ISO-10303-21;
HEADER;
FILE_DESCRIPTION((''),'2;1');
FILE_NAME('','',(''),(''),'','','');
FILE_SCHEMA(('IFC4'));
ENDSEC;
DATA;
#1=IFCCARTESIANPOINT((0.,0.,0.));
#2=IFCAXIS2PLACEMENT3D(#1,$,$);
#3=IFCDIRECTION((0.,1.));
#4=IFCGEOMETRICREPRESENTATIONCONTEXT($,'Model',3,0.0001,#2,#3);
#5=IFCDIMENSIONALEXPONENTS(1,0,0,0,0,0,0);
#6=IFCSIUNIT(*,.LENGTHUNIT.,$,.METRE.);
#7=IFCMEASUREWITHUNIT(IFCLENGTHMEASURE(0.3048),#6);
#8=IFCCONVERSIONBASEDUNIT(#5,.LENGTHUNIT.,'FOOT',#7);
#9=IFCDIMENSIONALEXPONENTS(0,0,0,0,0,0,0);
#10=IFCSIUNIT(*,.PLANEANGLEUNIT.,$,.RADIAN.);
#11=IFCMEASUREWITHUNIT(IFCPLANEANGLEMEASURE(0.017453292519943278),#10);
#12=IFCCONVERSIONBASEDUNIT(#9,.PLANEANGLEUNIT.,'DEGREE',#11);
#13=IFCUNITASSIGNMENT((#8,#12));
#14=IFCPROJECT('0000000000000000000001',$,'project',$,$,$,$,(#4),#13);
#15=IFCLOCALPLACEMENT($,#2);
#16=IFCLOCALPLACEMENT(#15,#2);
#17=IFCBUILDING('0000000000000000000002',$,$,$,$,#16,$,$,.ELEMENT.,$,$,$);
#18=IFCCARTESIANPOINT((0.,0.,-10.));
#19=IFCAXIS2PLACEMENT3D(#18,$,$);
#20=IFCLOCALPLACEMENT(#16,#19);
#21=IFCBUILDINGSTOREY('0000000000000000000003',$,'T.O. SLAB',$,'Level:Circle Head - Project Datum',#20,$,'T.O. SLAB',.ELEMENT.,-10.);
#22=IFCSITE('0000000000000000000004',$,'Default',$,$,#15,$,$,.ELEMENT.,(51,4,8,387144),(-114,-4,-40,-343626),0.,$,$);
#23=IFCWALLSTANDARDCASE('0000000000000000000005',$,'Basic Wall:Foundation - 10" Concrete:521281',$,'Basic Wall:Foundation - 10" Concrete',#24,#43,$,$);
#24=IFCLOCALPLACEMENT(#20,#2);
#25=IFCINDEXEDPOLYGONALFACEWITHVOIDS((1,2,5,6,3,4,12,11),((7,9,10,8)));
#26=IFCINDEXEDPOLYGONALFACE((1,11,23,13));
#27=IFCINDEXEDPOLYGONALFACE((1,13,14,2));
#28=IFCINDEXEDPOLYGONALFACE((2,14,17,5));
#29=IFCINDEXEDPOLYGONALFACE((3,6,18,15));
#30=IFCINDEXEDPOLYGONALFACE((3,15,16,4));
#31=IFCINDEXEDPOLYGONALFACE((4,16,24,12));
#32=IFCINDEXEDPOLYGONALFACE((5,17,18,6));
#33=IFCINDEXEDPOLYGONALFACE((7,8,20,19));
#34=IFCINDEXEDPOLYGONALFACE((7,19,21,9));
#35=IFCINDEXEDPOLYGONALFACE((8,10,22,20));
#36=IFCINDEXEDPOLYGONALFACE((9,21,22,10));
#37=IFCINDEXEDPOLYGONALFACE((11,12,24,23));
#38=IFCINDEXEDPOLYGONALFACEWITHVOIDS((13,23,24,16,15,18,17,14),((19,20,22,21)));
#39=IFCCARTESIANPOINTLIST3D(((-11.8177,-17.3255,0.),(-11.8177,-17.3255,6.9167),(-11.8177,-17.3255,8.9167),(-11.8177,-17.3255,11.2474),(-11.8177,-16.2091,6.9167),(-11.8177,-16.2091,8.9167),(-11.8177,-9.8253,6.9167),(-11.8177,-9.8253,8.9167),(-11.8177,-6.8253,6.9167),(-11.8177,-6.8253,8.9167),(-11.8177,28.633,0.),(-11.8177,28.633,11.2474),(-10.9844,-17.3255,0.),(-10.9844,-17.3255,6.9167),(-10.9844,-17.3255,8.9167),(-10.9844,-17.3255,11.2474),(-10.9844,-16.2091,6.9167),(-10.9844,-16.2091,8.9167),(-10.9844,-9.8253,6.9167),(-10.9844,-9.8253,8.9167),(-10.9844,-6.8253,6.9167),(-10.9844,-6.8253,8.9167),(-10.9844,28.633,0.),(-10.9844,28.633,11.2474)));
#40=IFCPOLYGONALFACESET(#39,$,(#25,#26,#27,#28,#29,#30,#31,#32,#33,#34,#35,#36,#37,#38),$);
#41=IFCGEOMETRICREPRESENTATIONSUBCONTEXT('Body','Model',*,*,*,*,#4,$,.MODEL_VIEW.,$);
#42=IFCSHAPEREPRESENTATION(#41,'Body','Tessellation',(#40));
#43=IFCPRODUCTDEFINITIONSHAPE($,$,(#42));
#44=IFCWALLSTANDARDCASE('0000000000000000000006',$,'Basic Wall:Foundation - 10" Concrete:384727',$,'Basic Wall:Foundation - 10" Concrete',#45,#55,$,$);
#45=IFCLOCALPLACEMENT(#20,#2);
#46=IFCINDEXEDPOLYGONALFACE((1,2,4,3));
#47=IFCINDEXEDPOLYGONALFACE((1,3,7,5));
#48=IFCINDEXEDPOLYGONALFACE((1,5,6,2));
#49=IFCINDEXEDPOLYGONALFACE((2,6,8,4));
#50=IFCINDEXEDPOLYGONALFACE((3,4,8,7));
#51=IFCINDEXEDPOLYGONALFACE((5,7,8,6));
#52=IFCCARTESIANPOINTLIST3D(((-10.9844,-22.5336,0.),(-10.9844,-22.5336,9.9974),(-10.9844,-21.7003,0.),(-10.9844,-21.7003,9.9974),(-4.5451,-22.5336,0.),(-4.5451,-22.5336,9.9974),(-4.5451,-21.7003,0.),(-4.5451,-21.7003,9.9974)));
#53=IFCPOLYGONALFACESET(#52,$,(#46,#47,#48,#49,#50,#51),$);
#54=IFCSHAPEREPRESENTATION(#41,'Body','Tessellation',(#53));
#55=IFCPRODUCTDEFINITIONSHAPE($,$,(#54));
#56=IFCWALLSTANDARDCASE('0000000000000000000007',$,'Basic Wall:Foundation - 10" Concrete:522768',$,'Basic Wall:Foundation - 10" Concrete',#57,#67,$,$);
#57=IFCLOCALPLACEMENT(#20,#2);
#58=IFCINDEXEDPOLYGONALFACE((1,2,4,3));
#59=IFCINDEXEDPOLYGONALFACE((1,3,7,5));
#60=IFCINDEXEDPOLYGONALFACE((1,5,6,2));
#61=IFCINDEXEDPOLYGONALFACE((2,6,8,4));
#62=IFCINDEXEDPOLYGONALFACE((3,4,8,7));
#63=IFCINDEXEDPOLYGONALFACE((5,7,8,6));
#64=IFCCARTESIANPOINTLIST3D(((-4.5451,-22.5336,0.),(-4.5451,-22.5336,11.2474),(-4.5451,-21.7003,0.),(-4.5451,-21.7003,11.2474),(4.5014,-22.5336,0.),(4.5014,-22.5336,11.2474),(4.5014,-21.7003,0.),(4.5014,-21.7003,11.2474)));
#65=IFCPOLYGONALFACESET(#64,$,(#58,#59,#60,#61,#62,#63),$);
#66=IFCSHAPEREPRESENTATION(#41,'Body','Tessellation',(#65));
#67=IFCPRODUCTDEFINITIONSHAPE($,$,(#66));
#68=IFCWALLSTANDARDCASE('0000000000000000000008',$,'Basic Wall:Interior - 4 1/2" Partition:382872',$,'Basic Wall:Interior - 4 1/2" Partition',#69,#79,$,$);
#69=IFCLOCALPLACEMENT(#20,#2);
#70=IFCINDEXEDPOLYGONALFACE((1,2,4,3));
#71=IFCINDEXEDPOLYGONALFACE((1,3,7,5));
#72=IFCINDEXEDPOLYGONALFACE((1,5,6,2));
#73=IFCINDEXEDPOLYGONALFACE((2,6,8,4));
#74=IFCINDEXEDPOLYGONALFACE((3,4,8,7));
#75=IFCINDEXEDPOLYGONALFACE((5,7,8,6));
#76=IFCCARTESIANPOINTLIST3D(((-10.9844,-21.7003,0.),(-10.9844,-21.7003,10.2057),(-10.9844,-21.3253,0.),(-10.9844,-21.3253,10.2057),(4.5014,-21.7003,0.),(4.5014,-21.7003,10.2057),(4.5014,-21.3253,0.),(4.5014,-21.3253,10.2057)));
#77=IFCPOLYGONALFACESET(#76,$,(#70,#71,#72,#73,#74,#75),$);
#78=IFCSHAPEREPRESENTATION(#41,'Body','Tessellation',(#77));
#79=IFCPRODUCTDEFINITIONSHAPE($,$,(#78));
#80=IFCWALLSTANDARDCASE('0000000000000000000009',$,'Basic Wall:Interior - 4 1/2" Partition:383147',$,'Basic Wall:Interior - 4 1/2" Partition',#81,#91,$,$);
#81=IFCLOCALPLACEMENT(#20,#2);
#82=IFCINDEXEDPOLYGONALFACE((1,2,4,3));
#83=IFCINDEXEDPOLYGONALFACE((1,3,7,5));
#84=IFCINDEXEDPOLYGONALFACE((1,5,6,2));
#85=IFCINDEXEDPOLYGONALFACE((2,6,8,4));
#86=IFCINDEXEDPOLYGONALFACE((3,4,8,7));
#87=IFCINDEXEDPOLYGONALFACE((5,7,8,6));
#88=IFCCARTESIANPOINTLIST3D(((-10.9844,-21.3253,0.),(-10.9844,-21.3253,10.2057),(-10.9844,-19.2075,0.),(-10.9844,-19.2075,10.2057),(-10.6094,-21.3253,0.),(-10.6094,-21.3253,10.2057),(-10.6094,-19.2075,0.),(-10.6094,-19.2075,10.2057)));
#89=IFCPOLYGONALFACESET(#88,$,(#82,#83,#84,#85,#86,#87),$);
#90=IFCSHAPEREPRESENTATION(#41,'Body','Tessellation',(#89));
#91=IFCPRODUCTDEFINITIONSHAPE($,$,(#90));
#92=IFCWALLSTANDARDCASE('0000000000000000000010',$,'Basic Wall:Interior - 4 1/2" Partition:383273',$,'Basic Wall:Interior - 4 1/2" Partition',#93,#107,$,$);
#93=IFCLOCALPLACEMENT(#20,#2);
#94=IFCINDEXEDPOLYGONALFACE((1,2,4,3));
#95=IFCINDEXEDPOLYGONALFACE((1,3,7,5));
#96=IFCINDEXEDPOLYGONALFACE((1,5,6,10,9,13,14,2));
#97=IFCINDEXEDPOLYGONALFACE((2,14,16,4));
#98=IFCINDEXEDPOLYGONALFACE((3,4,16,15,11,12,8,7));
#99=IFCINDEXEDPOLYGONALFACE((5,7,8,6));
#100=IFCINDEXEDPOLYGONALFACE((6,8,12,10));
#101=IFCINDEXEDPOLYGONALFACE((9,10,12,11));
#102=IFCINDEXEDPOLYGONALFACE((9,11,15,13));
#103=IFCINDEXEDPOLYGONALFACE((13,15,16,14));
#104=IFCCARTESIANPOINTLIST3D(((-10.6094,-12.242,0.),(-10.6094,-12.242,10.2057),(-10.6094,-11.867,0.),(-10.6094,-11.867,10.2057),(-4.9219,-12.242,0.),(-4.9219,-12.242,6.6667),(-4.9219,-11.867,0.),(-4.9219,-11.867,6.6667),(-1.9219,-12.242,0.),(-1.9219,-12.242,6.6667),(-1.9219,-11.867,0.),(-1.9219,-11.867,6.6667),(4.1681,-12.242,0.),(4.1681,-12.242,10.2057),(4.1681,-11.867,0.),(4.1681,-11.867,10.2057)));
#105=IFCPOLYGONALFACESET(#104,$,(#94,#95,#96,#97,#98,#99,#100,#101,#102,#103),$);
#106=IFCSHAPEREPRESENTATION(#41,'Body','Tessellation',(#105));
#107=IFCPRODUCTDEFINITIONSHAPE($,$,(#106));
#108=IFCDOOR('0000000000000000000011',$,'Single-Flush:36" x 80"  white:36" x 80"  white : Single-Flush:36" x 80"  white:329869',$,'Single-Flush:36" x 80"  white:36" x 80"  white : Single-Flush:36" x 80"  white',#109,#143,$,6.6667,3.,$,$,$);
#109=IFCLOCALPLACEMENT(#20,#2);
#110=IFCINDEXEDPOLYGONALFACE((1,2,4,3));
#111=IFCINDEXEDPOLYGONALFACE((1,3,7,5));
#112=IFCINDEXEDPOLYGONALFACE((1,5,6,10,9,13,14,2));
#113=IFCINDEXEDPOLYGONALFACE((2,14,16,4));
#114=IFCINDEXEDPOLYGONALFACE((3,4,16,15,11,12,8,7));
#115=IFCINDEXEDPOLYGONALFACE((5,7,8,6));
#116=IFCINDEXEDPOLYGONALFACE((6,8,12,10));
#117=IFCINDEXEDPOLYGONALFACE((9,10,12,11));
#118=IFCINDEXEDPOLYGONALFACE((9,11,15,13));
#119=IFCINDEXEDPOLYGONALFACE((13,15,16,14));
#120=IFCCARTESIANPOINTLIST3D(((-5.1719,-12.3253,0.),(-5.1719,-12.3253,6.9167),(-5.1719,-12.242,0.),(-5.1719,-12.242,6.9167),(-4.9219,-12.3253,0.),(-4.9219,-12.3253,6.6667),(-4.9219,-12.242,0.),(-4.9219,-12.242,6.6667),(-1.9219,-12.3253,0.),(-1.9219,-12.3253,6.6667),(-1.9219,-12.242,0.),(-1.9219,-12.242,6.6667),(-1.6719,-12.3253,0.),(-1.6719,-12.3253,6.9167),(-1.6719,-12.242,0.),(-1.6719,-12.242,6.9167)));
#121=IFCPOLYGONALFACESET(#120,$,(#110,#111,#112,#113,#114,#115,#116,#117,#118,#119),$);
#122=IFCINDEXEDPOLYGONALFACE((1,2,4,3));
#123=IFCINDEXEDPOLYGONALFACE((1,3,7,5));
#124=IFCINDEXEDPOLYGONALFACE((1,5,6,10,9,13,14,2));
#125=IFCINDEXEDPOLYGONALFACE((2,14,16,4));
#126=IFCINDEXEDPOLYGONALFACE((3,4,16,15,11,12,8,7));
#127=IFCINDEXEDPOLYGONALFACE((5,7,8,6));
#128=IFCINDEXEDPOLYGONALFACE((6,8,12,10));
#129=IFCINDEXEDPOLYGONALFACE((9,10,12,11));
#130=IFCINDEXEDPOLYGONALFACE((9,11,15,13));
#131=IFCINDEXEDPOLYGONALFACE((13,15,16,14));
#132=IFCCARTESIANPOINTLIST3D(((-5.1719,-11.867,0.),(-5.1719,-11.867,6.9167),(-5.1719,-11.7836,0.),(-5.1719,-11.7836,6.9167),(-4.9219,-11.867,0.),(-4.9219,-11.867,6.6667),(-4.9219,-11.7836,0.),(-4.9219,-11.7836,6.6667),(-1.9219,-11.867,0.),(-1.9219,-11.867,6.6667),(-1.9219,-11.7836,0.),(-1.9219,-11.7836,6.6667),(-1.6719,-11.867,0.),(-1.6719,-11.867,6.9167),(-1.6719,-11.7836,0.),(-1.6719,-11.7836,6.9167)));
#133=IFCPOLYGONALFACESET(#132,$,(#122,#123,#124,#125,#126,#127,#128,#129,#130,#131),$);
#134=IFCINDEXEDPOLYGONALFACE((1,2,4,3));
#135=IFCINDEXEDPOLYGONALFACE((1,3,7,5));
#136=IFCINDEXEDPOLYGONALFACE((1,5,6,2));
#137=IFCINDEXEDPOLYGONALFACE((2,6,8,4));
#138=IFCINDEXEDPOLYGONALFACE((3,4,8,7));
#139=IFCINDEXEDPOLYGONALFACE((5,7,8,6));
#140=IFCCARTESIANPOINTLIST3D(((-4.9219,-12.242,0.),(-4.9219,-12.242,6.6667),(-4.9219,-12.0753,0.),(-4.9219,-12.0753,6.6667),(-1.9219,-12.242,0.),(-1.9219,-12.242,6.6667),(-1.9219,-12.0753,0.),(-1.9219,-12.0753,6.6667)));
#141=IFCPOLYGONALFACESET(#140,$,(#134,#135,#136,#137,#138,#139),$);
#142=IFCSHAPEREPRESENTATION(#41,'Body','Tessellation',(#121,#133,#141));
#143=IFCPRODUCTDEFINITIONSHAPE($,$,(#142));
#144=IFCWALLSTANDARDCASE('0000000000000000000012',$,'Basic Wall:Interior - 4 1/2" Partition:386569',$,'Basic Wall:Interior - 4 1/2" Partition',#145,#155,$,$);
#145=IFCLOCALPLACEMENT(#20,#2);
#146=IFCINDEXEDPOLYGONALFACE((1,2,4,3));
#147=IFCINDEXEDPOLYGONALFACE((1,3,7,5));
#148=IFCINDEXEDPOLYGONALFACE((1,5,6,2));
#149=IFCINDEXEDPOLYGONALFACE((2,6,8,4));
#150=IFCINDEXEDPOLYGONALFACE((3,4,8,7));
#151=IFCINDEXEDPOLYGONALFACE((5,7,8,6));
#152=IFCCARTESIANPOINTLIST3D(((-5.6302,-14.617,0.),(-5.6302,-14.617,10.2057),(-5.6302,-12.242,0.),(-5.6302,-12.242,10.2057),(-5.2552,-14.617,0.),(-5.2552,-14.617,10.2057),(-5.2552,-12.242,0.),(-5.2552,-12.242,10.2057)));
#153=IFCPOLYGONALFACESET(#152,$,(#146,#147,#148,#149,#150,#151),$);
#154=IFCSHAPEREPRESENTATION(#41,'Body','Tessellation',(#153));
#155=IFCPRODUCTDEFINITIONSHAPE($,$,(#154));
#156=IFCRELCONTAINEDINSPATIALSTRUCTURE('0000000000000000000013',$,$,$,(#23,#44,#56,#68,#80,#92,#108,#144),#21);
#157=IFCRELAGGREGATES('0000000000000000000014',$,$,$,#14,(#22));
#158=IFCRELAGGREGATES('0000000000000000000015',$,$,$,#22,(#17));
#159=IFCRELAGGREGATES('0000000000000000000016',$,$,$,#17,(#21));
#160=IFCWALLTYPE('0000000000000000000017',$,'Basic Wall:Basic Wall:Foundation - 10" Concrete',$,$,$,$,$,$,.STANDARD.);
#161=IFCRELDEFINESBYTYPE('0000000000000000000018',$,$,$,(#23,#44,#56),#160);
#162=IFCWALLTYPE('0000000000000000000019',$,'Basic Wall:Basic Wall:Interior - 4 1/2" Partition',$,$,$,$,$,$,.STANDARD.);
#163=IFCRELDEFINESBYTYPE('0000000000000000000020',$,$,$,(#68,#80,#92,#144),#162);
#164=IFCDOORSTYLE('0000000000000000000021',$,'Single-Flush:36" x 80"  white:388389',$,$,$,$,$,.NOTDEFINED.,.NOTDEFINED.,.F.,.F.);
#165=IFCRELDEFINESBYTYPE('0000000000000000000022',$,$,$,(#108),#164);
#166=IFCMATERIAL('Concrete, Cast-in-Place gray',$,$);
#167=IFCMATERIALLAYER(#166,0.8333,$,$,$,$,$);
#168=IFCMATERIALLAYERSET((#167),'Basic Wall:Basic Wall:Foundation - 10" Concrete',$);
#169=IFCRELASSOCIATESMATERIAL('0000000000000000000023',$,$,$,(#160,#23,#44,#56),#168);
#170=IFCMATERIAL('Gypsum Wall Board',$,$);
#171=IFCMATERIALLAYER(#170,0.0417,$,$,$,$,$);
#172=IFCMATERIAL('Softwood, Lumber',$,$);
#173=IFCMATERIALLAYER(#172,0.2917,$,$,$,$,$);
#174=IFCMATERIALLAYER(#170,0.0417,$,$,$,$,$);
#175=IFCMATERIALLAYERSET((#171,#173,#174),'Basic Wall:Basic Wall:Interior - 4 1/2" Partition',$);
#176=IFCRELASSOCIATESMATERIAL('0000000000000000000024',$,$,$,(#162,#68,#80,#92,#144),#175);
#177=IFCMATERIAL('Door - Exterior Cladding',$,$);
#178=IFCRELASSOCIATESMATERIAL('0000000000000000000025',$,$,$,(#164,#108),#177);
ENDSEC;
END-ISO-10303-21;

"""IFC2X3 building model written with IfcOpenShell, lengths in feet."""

from ifc_helpers import new_model, entity, si_unit, converted_unit, direction, frame, frame_2d, origin, origin_2d_with_axis, place, context, subcontext, project, spatial, polyline, rectangle, outline, extrude, source, transform, mapped, material, layer, layer_set, layer_usage, type_object, type_shapes, element, fill, save


model = new_model("IFC2X3")

# Units and contexts
model_context = context("Model", 3, precision=0.0001, world=origin(), true_north=direction((0.0, 1.0)))
body_context = subcontext(model_context, "Body", "Model", "MODEL_VIEW")
ifc_project = project(units=[converted_unit("LENGTHUNIT", "FOOT", entity("IfcLengthMeasure", 0.3048), si_unit("LENGTHUNIT", "METRE"), dimensions=[1, 0, 0, 0, 0, 0, 0]), converted_unit("PLANEANGLEUNIT", "DEGREE", entity("IfcPlaneAngleMeasure", 0.017453292519943278), si_unit("PLANEANGLEUNIT", "RADIAN"), dimensions=[0, 0, 0, 0, 0, 0, 0])], contexts=[model_context])

# Site, building, storey
site_placement = place(None, origin())
site = spatial("IfcSite", under=ifc_project, at=site_placement, Name="Default", CompositionType="ELEMENT", RefLatitude=(51, 4, 8, 387144), RefLongitude=(-114, -4, -40, -343626), RefElevation=0.0)
building_placement = place(site_placement, origin())
building = spatial("IfcBuilding", under=site, at=building_placement, CompositionType="ELEMENT")
storey_placement = place(building_placement, frame((0.0, 0.0, -10.0)))
storey = spatial("IfcBuildingStorey", under=building, at=storey_placement, Name="T.O. SLAB", ObjectType="Level:Circle Head - Project Datum", LongName="T.O. SLAB", CompositionType="ELEMENT", Elevation=-10.0)

# Wall, openings
ifc_material_1 = material(Name="Concrete, Cast-in-Place gray")
ifc_layer_1 = layer(ifc_material_1, 0.8333)
ifc_layer_set_1 = layer_set([ifc_layer_1], Name="Basic Wall:Basic Wall:Foundation - 10\" Concrete")
ifc_layer_usage_1 = layer_usage(ifc_layer_set_1, "AXIS2", "NEGATIVE", 0.4167)
wall_type_1 = type_object("IfcWallType", Name="Basic Wall:Basic Wall:Foundation - 10\" Concrete", PredefinedType="STANDARD", material=ifc_layer_set_1)
wall_1_placement = place(storey_placement, frame((-11.401, -17.3255, 0.0), z_axis=(0.0, 0.0, 1.0), x_axis=(0.0, 1.0, 0.0)))
wall_1 = element("IfcWallStandardCase", 1, at=wall_1_placement, inside=storey, type_object=wall_type_1, material=ifc_layer_usage_1, Name="Basic Wall:Foundation - 10\" Concrete:521281", ObjectType="Basic Wall:Foundation - 10\" Concrete", context=body_context, shape_type="SweptSolid", body=[
    extrude(rectangle(XDim=45.9585, YDim=0.8333, at=frame_2d((22.9792, 0.0), x_axis=(-1.0, 0.0))), origin(), (0.0, 0.0, 1.0), 11.2474),
])
opening_1_placement = place(wall_1_placement, origin())
element("IfcOpeningElement", 2, at=opening_1_placement, cuts=wall_1, ObjectType="Opening", context=body_context, shape_type="SweptSolid", body=[
    extrude(rectangle(XDim=2.0, YDim=3.0, at=origin_2d_with_axis()), frame((-0.3836, -0.4167, 7.9167), z_axis=(0.0, 1.0, 0.0), x_axis=(0.0, 0.0, -1.0)), (0.0, 0.0, 1.0), 0.8333),
])
opening_2_placement = place(wall_1_placement, frame((17.3255, -11.401, 0.0), z_axis=(0.0, 0.0, 1.0), x_axis=(0.0, -1.0, 0.0)))
element("IfcOpeningElement", 3, at=opening_2_placement, cuts=wall_1, ObjectType="Opening", context=body_context, shape_type="SweptSolid", body=[
    extrude(rectangle(XDim=2.0, YDim=3.0, at=origin_2d_with_axis()), frame((-10.976, -8.3253, 7.9167), z_axis=(-1.0, 0.0, 0.0), x_axis=(0.0, 0.0, 1.0)), (0.0, 0.0, 1.0), 0.85),
])

# Walls
ifc_layer_usage_2 = layer_usage(ifc_layer_set_1, "AXIS2", "NEGATIVE", 0.4167)
wall_2_placement = place(storey_placement, frame((-10.9844, -22.117, 0.0)))
element("IfcWallStandardCase", 4, at=wall_2_placement, inside=storey, type_object=wall_type_1, material=ifc_layer_usage_2, Name="Basic Wall:Foundation - 10\" Concrete:384727", ObjectType="Basic Wall:Foundation - 10\" Concrete", context=body_context, shape_type="SweptSolid", body=[
    extrude(rectangle(XDim=6.4392, YDim=0.8333, at=frame_2d((3.2196, 0.0), x_axis=(-1.0, 0.0))), origin(), (0.0, 0.0, 1.0), 9.9974),
])
ifc_layer_usage_3 = layer_usage(ifc_layer_set_1, "AXIS2", "NEGATIVE", 0.4167)
wall_3_placement = place(storey_placement, frame((-4.5451, -22.117, 0.0)))
element("IfcWallStandardCase", 5, at=wall_3_placement, inside=storey, type_object=wall_type_1, material=ifc_layer_usage_3, Name="Basic Wall:Foundation - 10\" Concrete:522768", ObjectType="Basic Wall:Foundation - 10\" Concrete", context=body_context, shape_type="SweptSolid", body=[
    extrude(rectangle(XDim=9.0466, YDim=0.8333, at=frame_2d((4.5233, 0.0), x_axis=(-1.0, 0.0))), origin(), (0.0, 0.0, 1.0), 11.2474),
])
ifc_material_2 = material(Name="Gypsum Wall Board")
ifc_layer_2 = layer(ifc_material_2, 0.0417)
ifc_material_3 = material(Name="Softwood, Lumber")
ifc_layer_3 = layer(ifc_material_3, 0.2917)
ifc_layer_4 = layer(ifc_material_2, 0.0417)
ifc_layer_set_2 = layer_set([ifc_layer_2, ifc_layer_3, ifc_layer_4], Name="Basic Wall:Basic Wall:Interior - 4 1/2\" Partition")
ifc_layer_usage_4 = layer_usage(ifc_layer_set_2, "AXIS2", "NEGATIVE", 0.1875)
wall_type_2 = type_object("IfcWallType", Name="Basic Wall:Basic Wall:Interior - 4 1/2\" Partition", PredefinedType="STANDARD", material=ifc_layer_set_2)
wall_4_placement = place(storey_placement, frame((4.5014, -21.5128, 0.0), z_axis=(0.0, 0.0, 1.0), x_axis=(-1.0, 0.0, 0.0)))
element("IfcWallStandardCase", 6, at=wall_4_placement, inside=storey, type_object=wall_type_2, material=ifc_layer_usage_4, Name="Basic Wall:Interior - 4 1/2\" Partition:382872", ObjectType="Basic Wall:Interior - 4 1/2\" Partition", context=body_context, shape_type="SweptSolid", body=[
    extrude(rectangle(XDim=15.4858, YDim=0.375, at=frame_2d((7.7429, 0.0), x_axis=(-1.0, 0.0))), origin(), (0.0, 0.0, 1.0), 10.2057),
])
ifc_layer_usage_5 = layer_usage(ifc_layer_set_2, "AXIS2", "NEGATIVE", 0.1875)
wall_5_placement = place(storey_placement, frame((-10.7969, -21.3253, 0.0), z_axis=(0.0, 0.0, 1.0), x_axis=(0.0, 1.0, 0.0)))
element("IfcWallStandardCase", 7, at=wall_5_placement, inside=storey, type_object=wall_type_2, material=ifc_layer_usage_5, Name="Basic Wall:Interior - 4 1/2\" Partition:383147", ObjectType="Basic Wall:Interior - 4 1/2\" Partition", context=body_context, shape_type="SweptSolid", body=[
    extrude(rectangle(XDim=2.1178, YDim=0.375, at=frame_2d((1.0589, 0.0), x_axis=(-1.0, 0.0))), origin(), (0.0, 0.0, 1.0), 10.2057),
])

# Wall, opening, door
ifc_layer_usage_6 = layer_usage(ifc_layer_set_2, "AXIS2", "NEGATIVE", 0.1875)
wall_6_placement = place(storey_placement, frame((4.1681, -12.0545, 0.0), z_axis=(0.0, 0.0, 1.0), x_axis=(-1.0, 0.0, 0.0)))
wall_6 = element("IfcWallStandardCase", 8, at=wall_6_placement, inside=storey, type_object=wall_type_2, material=ifc_layer_usage_6, Name="Basic Wall:Interior - 4 1/2\" Partition:383273", ObjectType="Basic Wall:Interior - 4 1/2\" Partition", context=body_context, shape_type="SweptSolid", body=[
    extrude(rectangle(XDim=14.7775, YDim=0.375, at=frame_2d((7.3887, 0.0), x_axis=(1.0, 0.0))), origin(), (0.0, 0.0, 1.0), 10.2057),
])
opening_3_placement = place(wall_6_placement, frame((4.1681, -12.0545, 0.0), z_axis=(0.0, 0.0, 1.0), x_axis=(-1.0, 0.0, 0.0)))
opening_3 = element("IfcOpeningElement", 9, at=opening_3_placement, cuts=wall_6, ObjectType="Opening", context=body_context, shape_type="SweptSolid", body=[
    extrude(rectangle(XDim=6.6667, YDim=3.0, at=frame_2d((0.0, 0.0), x_axis=(1.0, 0.0))), frame((-3.4219, -11.8632, 3.3333), z_axis=(0.0, -1.0, 0.0), x_axis=(0.0, 0.0, -1.0)), (0.0, 0.0, 1.0), 0.3825),
])
ifc_material_4 = material(Name="Door - Exterior Cladding")
door_style_1 = type_object("IfcDoorStyle", Name="Single-Flush:36\" x 80\"  white:388389", ConstructionType="NOTDEFINED", OperationType="NOTDEFINED", ParameterTakesPrecedence=False, Sizeable=False, material=ifc_material_4)
shared_shape_1 = source(origin(), body_context, "Body", "SweptSolid", [
    extrude(outline(polyline([(-3.5208, -1.75), (3.3958, -1.75), (3.3958, -1.5), (-3.2708, -1.5), (-3.2708, 1.5), (3.3958, 1.5), (3.3958, 1.75), (-3.5208, 1.75), (-3.5208, -1.75)])), frame((1.5, -0.0038, 3.3958), z_axis=(0.0, 1.0, 0.0), x_axis=(0.0, 0.0, -1.0)), (0.0, 0.0, 1.0), 0.0833),
    extrude(outline(polyline([(-1.75, -3.3958), (-1.5, -3.3958), (-1.5, 3.2708), (1.5, 3.2708), (1.5, -3.3958), (1.75, -3.3958), (1.75, 3.5208), (-1.75, 3.5208), (-1.75, -3.3958)])), frame((1.5, -0.4621, 3.3958), z_axis=(0.0, 1.0, 0.0), x_axis=(-1.0, 0.0, 0.0)), (0.0, 0.0, 1.0), 0.0833),
    extrude(rectangle(XDim=3.0, YDim=0.1667, at=frame_2d((0.0, 0.0), x_axis=(1.0, 0.0))), frame((1.5, -0.0871, 0.0), z_axis=(0.0, 0.0, 1.0), x_axis=(-1.0, 0.0, 0.0)), (0.0, 0.0, 1.0), 6.6667),
])
type_shapes(door_style_1, [shared_shape_1])
door_1_placement = place(opening_3_placement, frame((-1.9219, -12.2457, 0.0), z_axis=(0.0, 0.0, 1.0), x_axis=(-1.0, 0.0, 0.0)))
door_1 = element("IfcDoor", 10, at=door_1_placement, inside=storey, type_object=door_style_1, material=ifc_material_4, Name="Single-Flush:36\" x 80\"  white:36\" x 80\"  white : Single-Flush:36\" x 80\"  white:329869", ObjectType="Single-Flush:36\" x 80\"  white:36\" x 80\"  white : Single-Flush:36\" x 80\"  white", OverallHeight=6.6667, OverallWidth=3.0, context=body_context, shape_type="MappedRepresentation", body=[
    mapped(shared_shape_1, transform((0.0, 0.0, 0.0), scale=1.0)),
])
fill(opening_3, door_1)

# Wall
ifc_layer_usage_7 = layer_usage(ifc_layer_set_2, "AXIS2", "NEGATIVE", 0.1875)
wall_7_placement = place(storey_placement, frame((-5.4427, -12.242, 0.0), z_axis=(0.0, 0.0, 1.0), x_axis=(0.0, -1.0, 0.0)))
element("IfcWallStandardCase", 11, at=wall_7_placement, inside=storey, type_object=wall_type_2, material=ifc_layer_usage_7, Name="Basic Wall:Interior - 4 1/2\" Partition:386569", ObjectType="Basic Wall:Interior - 4 1/2\" Partition", context=body_context, shape_type="SweptSolid", body=[
    extrude(rectangle(XDim=2.375, YDim=0.375, at=frame_2d((1.1875, 0.0), x_axis=(-1.0, 0.0))), origin(), (0.0, 0.0, 1.0), 10.2057),
])

save(model, "model.ifc")
